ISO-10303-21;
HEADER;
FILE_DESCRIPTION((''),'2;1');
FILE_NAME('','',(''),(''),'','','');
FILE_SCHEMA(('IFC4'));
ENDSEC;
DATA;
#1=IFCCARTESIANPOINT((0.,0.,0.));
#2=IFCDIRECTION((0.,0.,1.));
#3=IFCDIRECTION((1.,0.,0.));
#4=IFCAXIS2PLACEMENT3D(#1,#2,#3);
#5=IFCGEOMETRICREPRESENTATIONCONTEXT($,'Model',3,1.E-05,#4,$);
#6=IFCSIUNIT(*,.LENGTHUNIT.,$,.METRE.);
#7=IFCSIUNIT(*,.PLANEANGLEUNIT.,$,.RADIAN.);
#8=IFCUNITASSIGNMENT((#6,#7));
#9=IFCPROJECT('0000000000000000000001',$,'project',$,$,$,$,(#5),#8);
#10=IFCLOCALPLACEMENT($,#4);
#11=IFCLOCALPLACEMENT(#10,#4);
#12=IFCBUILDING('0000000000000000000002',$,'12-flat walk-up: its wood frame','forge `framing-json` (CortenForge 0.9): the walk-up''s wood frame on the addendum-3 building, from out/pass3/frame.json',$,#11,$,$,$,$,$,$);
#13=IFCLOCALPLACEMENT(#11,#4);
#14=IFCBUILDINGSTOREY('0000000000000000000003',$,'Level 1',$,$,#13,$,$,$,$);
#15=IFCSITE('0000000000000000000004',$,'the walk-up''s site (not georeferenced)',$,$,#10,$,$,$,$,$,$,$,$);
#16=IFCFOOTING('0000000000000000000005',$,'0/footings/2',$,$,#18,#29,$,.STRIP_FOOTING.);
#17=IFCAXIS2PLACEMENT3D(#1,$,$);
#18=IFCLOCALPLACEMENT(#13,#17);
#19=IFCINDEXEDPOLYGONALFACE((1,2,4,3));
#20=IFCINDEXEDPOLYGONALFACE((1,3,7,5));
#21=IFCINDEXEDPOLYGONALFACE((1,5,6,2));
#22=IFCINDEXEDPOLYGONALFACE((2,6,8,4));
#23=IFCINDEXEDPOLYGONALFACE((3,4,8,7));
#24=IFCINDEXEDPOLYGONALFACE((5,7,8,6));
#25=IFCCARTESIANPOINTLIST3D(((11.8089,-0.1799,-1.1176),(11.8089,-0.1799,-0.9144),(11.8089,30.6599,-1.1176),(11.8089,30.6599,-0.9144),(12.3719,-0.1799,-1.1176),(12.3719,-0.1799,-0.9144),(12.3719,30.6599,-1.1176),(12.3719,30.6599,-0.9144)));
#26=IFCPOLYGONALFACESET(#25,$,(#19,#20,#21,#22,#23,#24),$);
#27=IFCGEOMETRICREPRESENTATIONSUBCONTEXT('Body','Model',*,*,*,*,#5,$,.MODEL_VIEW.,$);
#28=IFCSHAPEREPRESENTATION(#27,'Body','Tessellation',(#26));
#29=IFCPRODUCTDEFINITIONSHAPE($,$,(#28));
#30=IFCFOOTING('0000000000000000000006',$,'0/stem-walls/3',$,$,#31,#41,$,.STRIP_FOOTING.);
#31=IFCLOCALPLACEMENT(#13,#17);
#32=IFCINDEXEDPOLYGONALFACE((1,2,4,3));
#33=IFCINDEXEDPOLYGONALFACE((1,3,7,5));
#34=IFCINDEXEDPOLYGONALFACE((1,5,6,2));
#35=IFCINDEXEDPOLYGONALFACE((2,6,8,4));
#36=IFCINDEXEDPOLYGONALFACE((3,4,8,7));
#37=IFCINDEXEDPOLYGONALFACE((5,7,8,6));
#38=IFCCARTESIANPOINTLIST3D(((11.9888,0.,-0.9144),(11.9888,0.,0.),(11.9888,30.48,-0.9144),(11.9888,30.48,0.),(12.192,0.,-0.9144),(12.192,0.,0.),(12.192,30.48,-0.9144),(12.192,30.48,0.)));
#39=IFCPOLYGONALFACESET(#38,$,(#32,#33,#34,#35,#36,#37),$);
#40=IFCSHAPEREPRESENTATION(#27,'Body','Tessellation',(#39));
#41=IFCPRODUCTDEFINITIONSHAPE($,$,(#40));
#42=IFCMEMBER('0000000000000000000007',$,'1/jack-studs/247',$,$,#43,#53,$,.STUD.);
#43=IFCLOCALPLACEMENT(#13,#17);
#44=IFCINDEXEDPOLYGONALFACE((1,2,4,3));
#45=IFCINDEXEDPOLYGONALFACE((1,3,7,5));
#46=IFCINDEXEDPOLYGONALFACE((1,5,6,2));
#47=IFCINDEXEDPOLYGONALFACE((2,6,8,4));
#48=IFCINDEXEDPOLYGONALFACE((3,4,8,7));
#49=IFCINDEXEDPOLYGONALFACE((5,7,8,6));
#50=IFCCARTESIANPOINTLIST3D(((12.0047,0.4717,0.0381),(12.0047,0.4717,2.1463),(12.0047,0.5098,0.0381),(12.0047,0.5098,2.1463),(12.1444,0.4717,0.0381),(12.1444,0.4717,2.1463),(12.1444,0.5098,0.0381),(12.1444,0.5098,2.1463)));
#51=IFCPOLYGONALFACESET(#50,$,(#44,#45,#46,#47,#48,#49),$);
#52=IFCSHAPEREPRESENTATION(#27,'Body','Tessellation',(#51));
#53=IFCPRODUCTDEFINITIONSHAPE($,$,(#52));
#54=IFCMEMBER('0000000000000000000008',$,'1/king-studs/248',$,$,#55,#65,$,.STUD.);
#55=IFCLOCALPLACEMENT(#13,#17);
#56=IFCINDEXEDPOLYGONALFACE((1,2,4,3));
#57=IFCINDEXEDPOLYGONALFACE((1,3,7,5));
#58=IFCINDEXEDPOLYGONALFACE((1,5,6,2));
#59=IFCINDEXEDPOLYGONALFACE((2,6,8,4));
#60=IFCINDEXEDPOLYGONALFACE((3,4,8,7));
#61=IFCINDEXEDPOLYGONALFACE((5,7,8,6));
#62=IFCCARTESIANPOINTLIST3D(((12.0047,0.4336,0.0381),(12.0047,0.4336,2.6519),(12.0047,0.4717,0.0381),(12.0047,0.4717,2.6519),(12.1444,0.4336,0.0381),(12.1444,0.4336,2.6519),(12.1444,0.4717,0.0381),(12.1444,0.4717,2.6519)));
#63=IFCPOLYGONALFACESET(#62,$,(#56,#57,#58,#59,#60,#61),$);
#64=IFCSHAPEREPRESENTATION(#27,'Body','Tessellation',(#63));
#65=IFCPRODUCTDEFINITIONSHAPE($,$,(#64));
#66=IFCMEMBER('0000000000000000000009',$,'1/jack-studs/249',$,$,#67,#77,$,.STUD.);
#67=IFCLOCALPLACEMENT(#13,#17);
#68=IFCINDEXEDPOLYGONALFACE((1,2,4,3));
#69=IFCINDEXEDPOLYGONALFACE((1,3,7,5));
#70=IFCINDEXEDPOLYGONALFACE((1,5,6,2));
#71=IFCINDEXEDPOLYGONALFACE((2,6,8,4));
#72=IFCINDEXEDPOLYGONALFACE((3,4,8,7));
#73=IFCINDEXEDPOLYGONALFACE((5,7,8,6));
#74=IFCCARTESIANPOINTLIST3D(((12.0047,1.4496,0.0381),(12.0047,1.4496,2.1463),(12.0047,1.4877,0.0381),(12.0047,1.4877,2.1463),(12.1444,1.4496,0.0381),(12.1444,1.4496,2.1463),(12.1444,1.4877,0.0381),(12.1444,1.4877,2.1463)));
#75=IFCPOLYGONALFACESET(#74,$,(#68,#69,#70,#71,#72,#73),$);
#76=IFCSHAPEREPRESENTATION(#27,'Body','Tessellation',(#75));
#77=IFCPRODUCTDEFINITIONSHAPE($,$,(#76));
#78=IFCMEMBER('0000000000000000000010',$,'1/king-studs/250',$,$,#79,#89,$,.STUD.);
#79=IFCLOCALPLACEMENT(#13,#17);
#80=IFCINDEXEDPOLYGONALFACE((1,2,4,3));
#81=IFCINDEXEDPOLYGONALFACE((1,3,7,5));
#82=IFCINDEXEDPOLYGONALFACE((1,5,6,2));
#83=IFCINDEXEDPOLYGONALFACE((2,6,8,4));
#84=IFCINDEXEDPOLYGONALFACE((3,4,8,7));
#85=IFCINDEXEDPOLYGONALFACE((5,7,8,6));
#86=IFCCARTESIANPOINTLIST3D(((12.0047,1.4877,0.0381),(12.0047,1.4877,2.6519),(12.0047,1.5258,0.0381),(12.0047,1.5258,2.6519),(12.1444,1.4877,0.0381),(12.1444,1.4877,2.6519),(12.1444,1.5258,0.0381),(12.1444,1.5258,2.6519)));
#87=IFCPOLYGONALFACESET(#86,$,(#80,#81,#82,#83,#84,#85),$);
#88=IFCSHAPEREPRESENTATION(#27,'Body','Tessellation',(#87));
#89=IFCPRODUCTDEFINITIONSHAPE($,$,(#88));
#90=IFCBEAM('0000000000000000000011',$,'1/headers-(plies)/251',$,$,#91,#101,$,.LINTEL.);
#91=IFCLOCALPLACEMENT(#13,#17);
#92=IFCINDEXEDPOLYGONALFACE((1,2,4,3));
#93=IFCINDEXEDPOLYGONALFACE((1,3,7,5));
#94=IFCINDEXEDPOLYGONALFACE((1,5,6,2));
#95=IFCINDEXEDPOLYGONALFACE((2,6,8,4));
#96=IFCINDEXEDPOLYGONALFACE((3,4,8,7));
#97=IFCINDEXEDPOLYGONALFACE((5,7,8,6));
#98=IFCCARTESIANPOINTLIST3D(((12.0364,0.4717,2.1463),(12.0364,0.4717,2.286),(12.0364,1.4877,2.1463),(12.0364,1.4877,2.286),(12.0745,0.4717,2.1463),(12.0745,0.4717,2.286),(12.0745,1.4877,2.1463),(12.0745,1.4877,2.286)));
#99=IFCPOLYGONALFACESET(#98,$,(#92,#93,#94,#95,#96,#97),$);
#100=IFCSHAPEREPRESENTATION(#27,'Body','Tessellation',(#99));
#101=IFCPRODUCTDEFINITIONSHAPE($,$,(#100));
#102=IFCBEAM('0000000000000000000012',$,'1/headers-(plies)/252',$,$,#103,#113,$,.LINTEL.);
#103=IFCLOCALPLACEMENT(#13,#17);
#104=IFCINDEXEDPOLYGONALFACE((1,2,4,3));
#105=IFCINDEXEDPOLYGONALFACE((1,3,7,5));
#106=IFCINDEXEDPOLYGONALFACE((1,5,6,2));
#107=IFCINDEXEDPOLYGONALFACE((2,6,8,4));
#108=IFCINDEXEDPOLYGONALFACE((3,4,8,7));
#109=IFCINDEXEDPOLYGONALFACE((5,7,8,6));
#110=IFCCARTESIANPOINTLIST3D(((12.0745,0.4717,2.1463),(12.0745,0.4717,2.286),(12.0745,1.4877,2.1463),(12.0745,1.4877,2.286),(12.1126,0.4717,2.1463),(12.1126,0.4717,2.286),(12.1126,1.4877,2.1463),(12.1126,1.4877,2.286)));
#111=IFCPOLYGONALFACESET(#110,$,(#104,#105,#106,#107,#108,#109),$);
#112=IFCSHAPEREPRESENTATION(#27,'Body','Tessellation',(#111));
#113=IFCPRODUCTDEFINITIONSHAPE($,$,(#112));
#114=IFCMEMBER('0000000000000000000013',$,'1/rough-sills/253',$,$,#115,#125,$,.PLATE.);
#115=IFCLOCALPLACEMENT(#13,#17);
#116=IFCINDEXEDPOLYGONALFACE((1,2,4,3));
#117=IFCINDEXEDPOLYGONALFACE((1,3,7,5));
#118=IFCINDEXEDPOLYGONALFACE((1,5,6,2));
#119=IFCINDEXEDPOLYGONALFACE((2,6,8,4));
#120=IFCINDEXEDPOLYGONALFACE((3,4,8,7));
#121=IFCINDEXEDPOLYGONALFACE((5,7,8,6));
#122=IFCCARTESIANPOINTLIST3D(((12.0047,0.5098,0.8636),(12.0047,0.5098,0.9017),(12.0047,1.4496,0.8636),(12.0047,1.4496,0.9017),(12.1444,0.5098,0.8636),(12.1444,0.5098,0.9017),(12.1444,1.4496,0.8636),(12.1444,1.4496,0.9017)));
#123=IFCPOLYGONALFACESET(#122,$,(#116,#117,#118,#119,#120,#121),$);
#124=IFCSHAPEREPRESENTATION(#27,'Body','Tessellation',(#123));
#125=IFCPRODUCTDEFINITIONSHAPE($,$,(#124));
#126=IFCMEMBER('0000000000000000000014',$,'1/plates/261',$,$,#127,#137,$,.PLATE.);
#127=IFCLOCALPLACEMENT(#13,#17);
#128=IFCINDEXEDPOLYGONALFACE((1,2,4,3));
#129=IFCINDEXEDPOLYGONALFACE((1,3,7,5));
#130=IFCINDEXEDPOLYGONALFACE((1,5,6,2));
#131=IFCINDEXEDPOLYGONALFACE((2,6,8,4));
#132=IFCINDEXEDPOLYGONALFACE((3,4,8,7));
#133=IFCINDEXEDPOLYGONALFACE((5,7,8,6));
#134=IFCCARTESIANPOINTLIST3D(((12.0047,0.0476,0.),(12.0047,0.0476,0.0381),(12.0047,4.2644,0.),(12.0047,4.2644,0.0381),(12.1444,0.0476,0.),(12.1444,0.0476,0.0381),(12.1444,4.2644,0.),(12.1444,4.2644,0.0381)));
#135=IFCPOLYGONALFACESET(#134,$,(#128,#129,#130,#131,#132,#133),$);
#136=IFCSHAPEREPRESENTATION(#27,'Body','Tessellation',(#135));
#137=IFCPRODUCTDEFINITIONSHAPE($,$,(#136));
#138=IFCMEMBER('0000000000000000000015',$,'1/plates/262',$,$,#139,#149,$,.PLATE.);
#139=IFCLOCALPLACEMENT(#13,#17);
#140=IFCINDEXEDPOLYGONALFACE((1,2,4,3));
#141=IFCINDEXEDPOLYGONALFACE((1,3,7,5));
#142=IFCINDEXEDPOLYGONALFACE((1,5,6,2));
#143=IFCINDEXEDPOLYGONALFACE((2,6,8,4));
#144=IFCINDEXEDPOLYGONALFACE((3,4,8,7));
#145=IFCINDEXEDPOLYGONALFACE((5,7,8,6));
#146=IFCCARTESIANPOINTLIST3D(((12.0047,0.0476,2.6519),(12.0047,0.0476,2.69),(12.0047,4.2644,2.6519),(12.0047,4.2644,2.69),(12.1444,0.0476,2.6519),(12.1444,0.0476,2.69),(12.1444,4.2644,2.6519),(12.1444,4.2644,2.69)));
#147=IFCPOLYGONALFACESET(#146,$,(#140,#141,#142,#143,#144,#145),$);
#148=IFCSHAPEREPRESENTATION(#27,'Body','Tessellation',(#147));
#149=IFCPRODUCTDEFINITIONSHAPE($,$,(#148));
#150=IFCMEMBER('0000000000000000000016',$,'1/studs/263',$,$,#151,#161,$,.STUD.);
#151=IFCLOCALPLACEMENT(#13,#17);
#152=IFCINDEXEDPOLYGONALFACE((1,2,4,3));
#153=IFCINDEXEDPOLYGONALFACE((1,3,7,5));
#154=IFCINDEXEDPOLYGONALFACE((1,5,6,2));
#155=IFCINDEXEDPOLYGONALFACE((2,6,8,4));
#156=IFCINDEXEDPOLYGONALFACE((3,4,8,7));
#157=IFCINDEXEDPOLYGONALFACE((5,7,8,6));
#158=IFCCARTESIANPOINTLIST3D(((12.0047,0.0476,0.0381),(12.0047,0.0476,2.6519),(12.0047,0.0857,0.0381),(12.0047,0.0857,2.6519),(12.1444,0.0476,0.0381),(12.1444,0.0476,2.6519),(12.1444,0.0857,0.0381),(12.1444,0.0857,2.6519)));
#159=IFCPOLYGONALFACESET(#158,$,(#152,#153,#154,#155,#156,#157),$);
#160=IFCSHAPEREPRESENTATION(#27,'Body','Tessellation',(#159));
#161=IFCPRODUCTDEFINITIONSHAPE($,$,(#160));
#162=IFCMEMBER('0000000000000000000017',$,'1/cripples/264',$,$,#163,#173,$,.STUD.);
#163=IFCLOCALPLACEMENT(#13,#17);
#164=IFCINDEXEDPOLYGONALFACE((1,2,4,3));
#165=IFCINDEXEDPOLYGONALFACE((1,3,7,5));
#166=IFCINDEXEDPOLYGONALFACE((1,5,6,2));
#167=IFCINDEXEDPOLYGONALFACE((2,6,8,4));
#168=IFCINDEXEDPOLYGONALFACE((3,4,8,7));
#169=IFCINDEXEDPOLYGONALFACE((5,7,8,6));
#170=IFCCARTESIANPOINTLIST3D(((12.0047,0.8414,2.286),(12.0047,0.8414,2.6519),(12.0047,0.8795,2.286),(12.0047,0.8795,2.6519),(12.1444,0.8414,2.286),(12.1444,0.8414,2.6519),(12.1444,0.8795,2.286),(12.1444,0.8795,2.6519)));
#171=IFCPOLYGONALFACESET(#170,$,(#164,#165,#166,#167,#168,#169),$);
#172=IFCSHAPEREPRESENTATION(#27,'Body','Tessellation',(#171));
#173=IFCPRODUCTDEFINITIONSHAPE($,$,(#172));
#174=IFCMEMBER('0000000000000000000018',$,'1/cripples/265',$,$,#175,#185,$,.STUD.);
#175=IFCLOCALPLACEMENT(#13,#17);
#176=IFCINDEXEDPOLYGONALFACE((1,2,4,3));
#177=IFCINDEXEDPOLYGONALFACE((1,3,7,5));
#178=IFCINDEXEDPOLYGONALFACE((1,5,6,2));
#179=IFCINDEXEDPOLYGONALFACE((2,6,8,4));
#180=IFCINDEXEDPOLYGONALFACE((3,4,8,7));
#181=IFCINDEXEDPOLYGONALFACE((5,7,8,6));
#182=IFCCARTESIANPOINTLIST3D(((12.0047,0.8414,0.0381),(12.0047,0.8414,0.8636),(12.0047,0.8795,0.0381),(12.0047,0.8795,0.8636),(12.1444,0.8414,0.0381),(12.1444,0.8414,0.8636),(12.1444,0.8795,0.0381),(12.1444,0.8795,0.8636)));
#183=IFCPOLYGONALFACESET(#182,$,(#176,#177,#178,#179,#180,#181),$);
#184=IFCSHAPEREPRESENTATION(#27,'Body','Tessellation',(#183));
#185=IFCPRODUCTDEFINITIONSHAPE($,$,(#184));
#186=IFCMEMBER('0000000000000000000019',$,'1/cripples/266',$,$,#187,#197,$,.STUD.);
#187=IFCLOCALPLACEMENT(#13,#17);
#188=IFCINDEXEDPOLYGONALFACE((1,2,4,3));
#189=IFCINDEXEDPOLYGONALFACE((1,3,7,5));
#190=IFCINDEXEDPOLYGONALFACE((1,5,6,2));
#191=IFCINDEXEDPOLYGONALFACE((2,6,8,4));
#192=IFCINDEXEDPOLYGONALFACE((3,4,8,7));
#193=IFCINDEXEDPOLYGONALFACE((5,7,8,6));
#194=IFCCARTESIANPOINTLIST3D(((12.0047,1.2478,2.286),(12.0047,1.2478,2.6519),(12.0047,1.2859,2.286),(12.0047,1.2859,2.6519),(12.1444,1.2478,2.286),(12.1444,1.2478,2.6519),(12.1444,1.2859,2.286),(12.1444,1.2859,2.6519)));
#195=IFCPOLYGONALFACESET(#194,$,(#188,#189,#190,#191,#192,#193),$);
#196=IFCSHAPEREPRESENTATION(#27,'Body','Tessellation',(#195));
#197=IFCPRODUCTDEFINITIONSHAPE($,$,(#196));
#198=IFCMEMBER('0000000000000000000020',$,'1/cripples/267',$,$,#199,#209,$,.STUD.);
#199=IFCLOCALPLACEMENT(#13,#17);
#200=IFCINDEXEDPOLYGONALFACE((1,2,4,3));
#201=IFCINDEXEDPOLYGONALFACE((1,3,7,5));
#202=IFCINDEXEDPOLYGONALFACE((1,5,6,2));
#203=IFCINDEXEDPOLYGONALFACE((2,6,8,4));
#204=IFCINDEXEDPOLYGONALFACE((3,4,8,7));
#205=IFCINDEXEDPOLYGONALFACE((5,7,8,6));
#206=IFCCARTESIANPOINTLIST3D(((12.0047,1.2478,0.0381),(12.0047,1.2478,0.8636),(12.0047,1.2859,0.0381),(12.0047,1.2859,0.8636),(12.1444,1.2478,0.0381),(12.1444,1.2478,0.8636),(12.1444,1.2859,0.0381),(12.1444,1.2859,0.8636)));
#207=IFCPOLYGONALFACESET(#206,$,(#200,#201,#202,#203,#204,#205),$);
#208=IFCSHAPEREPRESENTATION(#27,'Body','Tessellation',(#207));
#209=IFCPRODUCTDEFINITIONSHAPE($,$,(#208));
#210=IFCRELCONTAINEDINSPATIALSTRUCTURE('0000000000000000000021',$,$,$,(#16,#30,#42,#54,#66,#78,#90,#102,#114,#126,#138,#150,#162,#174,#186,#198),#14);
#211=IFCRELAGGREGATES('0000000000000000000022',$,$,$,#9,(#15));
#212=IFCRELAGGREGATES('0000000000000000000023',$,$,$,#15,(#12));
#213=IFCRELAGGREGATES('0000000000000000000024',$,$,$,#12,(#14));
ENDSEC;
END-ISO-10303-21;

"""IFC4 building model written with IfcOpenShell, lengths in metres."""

from ifc_helpers import new_model, si_unit, frame, frame_2d, origin, origin_with_axes, place, context, subcontext, project, spatial, rectangle, extrude, element, save


model = new_model("IFC4")

# Units and contexts
model_context = context("Model", 3, precision=1e-05, world=origin_with_axes())
body_context = subcontext(model_context, "Body", "Model", "MODEL_VIEW")
ifc_project = project(units=[si_unit("LENGTHUNIT", "METRE"), si_unit("PLANEANGLEUNIT", "RADIAN")], contexts=[model_context])

# Site, building, storey
site_placement = place(None, origin_with_axes())
site = spatial("IfcSite", under=ifc_project, at=site_placement, Name="the walk-up's site (not georeferenced)")
building_placement = place(site_placement, origin_with_axes())
building = spatial("IfcBuilding", under=site, at=building_placement, Name="12-flat walk-up: its wood frame", Description="forge `framing-json` (CortenForge 0.9): the walk-up's wood frame on the addendum-3 building, from out/pass3/frame.json")
storey_placement = place(building_placement, origin_with_axes())
storey = spatial("IfcBuildingStorey", under=building, at=storey_placement, Name="Level 1")

# Footings
footing_1_placement = place(storey_placement, frame((11.8089, -0.1799, -1.1176), z_axis=(0.0, 0.0, 1.0), x_axis=(1.0, 0.0, 0.0)))
element("IfcFooting", 1, at=footing_1_placement, inside=storey, Name="0/footings/2", PredefinedType="STRIP_FOOTING", context=body_context, shape_type="SweptSolid", body=[
    extrude(rectangle(XDim=0.5631, YDim=30.8399, at=frame_2d((0.2815, 15.4199))), origin(), (0.0, 0.0, 1.0), 0.2032),
])
footing_2_placement = place(storey_placement, frame((11.9888, 0.0, -0.9144), z_axis=(0.0, 0.0, 1.0), x_axis=(1.0, 0.0, 0.0)))
element("IfcFooting", 2, at=footing_2_placement, inside=storey, Name="0/stem-walls/3", PredefinedType="STRIP_FOOTING", context=body_context, shape_type="SweptSolid", body=[
    extrude(rectangle(XDim=0.2032, YDim=30.48, at=frame_2d((0.1016, 15.24))), origin(), (0.0, 0.0, 1.0), 0.9144),
])

# Members
member_1_placement = place(storey_placement, frame((12.0047, 0.4717, 0.0381), z_axis=(0.0, 0.0, 1.0), x_axis=(1.0, 0.0, 0.0)))
element("IfcMember", 3, at=member_1_placement, inside=storey, Name="1/jack-studs/247", PredefinedType="STUD", context=body_context, shape_type="SweptSolid", body=[
    extrude(rectangle(XDim=0.1397, YDim=0.0381, at=frame_2d((0.0698, 0.019))), origin(), (0.0, 0.0, 1.0), 2.1082),
])
member_2_placement = place(storey_placement, frame((12.0047, 0.4336, 0.0381), z_axis=(0.0, 0.0, 1.0), x_axis=(1.0, 0.0, 0.0)))
element("IfcMember", 4, at=member_2_placement, inside=storey, Name="1/king-studs/248", PredefinedType="STUD", context=body_context, shape_type="SweptSolid", body=[
    extrude(rectangle(XDim=0.1397, YDim=0.0381, at=frame_2d((0.0698, 0.0191))), origin(), (0.0, 0.0, 1.0), 2.6138),
])
member_3_placement = place(storey_placement, frame((12.0047, 1.4496, 0.0381), z_axis=(0.0, 0.0, 1.0), x_axis=(1.0, 0.0, 0.0)))
element("IfcMember", 5, at=member_3_placement, inside=storey, Name="1/jack-studs/249", PredefinedType="STUD", context=body_context, shape_type="SweptSolid", body=[
    extrude(rectangle(XDim=0.1397, YDim=0.0381, at=frame_2d((0.0698, 0.0191))), origin(), (0.0, 0.0, 1.0), 2.1082),
])
member_4_placement = place(storey_placement, frame((12.0047, 1.4877, 0.0381), z_axis=(0.0, 0.0, 1.0), x_axis=(1.0, 0.0, 0.0)))
element("IfcMember", 6, at=member_4_placement, inside=storey, Name="1/king-studs/250", PredefinedType="STUD", context=body_context, shape_type="SweptSolid", body=[
    extrude(rectangle(XDim=0.1397, YDim=0.0381, at=frame_2d((0.0698, 0.0191))), origin(), (0.0, 0.0, 1.0), 2.6138),
])

# Beams
for number, where, z_axis, x_axis, name in (
    (7, (12.0364, 0.4717, 2.1463), (0.0, 0.0, 1.0), (1.0, 0.0, 0.0), "1/headers-(plies)/251"),
    (8, (12.0745, 0.4717, 2.1463), (0.0, 0.0, 1.0), (1.0, 0.0, 0.0), "1/headers-(plies)/252"),
):
    element("IfcBeam", number, at=place(storey_placement, frame(where, z_axis=z_axis, x_axis=x_axis)), inside=storey, Name=name, PredefinedType="LINTEL", context=body_context, shape_type="SweptSolid", body=[
        extrude(rectangle(XDim=0.0381, YDim=1.016, at=frame_2d((0.0191, 0.508))), origin(), (0.0, 0.0, 1.0), 0.1397),
    ])

# Members
member_5_placement = place(storey_placement, frame((12.0047, 0.5098, 0.8636), z_axis=(0.0, 0.0, 1.0), x_axis=(1.0, 0.0, 0.0)))
element("IfcMember", 9, at=member_5_placement, inside=storey, Name="1/rough-sills/253", PredefinedType="PLATE", context=body_context, shape_type="SweptSolid", body=[
    extrude(rectangle(XDim=0.1397, YDim=0.9398, at=frame_2d((0.0698, 0.4699))), origin(), (0.0, 0.0, 1.0), 0.0381),
])
member_6_placement = place(storey_placement, frame((12.0047, 0.0476, 0.0), z_axis=(0.0, 0.0, 1.0), x_axis=(1.0, 0.0, 0.0)))
element("IfcMember", 10, at=member_6_placement, inside=storey, Name="1/plates/261", PredefinedType="PLATE", context=body_context, shape_type="SweptSolid", body=[
    extrude(rectangle(XDim=0.1397, YDim=4.2168, at=frame_2d((0.0698, 2.1084))), origin(), (0.0, 0.0, 1.0), 0.0381),
])
member_7_placement = place(storey_placement, frame((12.0047, 0.0476, 2.6519), z_axis=(0.0, 0.0, 1.0), x_axis=(1.0, 0.0, 0.0)))
element("IfcMember", 11, at=member_7_placement, inside=storey, Name="1/plates/262", PredefinedType="PLATE", context=body_context, shape_type="SweptSolid", body=[
    extrude(rectangle(XDim=0.1397, YDim=4.2168, at=frame_2d((0.0698, 2.1084))), origin(), (0.0, 0.0, 1.0), 0.0381),
])
member_8_placement = place(storey_placement, frame((12.0047, 0.0476, 0.0381), z_axis=(0.0, 0.0, 1.0), x_axis=(1.0, 0.0, 0.0)))
element("IfcMember", 12, at=member_8_placement, inside=storey, Name="1/studs/263", PredefinedType="STUD", context=body_context, shape_type="SweptSolid", body=[
    extrude(rectangle(XDim=0.1397, YDim=0.0381, at=frame_2d((0.0698, 0.019))), origin(), (0.0, 0.0, 1.0), 2.6138),
])
member_9_placement = place(storey_placement, frame((12.0047, 0.8414, 2.286), z_axis=(0.0, 0.0, 1.0), x_axis=(1.0, 0.0, 0.0)))
element("IfcMember", 13, at=member_9_placement, inside=storey, Name="1/cripples/264", PredefinedType="STUD", context=body_context, shape_type="SweptSolid", body=[
    extrude(rectangle(XDim=0.1397, YDim=0.0381, at=frame_2d((0.0698, 0.0191))), origin(), (0.0, 0.0, 1.0), 0.3659),
])
member_10_placement = place(storey_placement, frame((12.0047, 0.8414, 0.0381), z_axis=(0.0, 0.0, 1.0), x_axis=(1.0, 0.0, 0.0)))
element("IfcMember", 14, at=member_10_placement, inside=storey, Name="1/cripples/265", PredefinedType="STUD", context=body_context, shape_type="SweptSolid", body=[
    extrude(rectangle(XDim=0.1397, YDim=0.0381, at=frame_2d((0.0698, 0.0191))), origin(), (0.0, 0.0, 1.0), 0.8255),
])
member_11_placement = place(storey_placement, frame((12.0047, 1.2478, 2.286), z_axis=(0.0, 0.0, 1.0), x_axis=(1.0, 0.0, 0.0)))
element("IfcMember", 15, at=member_11_placement, inside=storey, Name="1/cripples/266", PredefinedType="STUD", context=body_context, shape_type="SweptSolid", body=[
    extrude(rectangle(XDim=0.1397, YDim=0.0381, at=frame_2d((0.0698, 0.0191))), origin(), (0.0, 0.0, 1.0), 0.3659),
])
member_12_placement = place(storey_placement, frame((12.0047, 1.2478, 0.0381), z_axis=(0.0, 0.0, 1.0), x_axis=(1.0, 0.0, 0.0)))
element("IfcMember", 16, at=member_12_placement, inside=storey, Name="1/cripples/267", PredefinedType="STUD", context=body_context, shape_type="SweptSolid", body=[
    extrude(rectangle(XDim=0.1397, YDim=0.0381, at=frame_2d((0.0698, 0.0191))), origin(), (0.0, 0.0, 1.0), 0.8255),
])

save(model, "model.ifc")
